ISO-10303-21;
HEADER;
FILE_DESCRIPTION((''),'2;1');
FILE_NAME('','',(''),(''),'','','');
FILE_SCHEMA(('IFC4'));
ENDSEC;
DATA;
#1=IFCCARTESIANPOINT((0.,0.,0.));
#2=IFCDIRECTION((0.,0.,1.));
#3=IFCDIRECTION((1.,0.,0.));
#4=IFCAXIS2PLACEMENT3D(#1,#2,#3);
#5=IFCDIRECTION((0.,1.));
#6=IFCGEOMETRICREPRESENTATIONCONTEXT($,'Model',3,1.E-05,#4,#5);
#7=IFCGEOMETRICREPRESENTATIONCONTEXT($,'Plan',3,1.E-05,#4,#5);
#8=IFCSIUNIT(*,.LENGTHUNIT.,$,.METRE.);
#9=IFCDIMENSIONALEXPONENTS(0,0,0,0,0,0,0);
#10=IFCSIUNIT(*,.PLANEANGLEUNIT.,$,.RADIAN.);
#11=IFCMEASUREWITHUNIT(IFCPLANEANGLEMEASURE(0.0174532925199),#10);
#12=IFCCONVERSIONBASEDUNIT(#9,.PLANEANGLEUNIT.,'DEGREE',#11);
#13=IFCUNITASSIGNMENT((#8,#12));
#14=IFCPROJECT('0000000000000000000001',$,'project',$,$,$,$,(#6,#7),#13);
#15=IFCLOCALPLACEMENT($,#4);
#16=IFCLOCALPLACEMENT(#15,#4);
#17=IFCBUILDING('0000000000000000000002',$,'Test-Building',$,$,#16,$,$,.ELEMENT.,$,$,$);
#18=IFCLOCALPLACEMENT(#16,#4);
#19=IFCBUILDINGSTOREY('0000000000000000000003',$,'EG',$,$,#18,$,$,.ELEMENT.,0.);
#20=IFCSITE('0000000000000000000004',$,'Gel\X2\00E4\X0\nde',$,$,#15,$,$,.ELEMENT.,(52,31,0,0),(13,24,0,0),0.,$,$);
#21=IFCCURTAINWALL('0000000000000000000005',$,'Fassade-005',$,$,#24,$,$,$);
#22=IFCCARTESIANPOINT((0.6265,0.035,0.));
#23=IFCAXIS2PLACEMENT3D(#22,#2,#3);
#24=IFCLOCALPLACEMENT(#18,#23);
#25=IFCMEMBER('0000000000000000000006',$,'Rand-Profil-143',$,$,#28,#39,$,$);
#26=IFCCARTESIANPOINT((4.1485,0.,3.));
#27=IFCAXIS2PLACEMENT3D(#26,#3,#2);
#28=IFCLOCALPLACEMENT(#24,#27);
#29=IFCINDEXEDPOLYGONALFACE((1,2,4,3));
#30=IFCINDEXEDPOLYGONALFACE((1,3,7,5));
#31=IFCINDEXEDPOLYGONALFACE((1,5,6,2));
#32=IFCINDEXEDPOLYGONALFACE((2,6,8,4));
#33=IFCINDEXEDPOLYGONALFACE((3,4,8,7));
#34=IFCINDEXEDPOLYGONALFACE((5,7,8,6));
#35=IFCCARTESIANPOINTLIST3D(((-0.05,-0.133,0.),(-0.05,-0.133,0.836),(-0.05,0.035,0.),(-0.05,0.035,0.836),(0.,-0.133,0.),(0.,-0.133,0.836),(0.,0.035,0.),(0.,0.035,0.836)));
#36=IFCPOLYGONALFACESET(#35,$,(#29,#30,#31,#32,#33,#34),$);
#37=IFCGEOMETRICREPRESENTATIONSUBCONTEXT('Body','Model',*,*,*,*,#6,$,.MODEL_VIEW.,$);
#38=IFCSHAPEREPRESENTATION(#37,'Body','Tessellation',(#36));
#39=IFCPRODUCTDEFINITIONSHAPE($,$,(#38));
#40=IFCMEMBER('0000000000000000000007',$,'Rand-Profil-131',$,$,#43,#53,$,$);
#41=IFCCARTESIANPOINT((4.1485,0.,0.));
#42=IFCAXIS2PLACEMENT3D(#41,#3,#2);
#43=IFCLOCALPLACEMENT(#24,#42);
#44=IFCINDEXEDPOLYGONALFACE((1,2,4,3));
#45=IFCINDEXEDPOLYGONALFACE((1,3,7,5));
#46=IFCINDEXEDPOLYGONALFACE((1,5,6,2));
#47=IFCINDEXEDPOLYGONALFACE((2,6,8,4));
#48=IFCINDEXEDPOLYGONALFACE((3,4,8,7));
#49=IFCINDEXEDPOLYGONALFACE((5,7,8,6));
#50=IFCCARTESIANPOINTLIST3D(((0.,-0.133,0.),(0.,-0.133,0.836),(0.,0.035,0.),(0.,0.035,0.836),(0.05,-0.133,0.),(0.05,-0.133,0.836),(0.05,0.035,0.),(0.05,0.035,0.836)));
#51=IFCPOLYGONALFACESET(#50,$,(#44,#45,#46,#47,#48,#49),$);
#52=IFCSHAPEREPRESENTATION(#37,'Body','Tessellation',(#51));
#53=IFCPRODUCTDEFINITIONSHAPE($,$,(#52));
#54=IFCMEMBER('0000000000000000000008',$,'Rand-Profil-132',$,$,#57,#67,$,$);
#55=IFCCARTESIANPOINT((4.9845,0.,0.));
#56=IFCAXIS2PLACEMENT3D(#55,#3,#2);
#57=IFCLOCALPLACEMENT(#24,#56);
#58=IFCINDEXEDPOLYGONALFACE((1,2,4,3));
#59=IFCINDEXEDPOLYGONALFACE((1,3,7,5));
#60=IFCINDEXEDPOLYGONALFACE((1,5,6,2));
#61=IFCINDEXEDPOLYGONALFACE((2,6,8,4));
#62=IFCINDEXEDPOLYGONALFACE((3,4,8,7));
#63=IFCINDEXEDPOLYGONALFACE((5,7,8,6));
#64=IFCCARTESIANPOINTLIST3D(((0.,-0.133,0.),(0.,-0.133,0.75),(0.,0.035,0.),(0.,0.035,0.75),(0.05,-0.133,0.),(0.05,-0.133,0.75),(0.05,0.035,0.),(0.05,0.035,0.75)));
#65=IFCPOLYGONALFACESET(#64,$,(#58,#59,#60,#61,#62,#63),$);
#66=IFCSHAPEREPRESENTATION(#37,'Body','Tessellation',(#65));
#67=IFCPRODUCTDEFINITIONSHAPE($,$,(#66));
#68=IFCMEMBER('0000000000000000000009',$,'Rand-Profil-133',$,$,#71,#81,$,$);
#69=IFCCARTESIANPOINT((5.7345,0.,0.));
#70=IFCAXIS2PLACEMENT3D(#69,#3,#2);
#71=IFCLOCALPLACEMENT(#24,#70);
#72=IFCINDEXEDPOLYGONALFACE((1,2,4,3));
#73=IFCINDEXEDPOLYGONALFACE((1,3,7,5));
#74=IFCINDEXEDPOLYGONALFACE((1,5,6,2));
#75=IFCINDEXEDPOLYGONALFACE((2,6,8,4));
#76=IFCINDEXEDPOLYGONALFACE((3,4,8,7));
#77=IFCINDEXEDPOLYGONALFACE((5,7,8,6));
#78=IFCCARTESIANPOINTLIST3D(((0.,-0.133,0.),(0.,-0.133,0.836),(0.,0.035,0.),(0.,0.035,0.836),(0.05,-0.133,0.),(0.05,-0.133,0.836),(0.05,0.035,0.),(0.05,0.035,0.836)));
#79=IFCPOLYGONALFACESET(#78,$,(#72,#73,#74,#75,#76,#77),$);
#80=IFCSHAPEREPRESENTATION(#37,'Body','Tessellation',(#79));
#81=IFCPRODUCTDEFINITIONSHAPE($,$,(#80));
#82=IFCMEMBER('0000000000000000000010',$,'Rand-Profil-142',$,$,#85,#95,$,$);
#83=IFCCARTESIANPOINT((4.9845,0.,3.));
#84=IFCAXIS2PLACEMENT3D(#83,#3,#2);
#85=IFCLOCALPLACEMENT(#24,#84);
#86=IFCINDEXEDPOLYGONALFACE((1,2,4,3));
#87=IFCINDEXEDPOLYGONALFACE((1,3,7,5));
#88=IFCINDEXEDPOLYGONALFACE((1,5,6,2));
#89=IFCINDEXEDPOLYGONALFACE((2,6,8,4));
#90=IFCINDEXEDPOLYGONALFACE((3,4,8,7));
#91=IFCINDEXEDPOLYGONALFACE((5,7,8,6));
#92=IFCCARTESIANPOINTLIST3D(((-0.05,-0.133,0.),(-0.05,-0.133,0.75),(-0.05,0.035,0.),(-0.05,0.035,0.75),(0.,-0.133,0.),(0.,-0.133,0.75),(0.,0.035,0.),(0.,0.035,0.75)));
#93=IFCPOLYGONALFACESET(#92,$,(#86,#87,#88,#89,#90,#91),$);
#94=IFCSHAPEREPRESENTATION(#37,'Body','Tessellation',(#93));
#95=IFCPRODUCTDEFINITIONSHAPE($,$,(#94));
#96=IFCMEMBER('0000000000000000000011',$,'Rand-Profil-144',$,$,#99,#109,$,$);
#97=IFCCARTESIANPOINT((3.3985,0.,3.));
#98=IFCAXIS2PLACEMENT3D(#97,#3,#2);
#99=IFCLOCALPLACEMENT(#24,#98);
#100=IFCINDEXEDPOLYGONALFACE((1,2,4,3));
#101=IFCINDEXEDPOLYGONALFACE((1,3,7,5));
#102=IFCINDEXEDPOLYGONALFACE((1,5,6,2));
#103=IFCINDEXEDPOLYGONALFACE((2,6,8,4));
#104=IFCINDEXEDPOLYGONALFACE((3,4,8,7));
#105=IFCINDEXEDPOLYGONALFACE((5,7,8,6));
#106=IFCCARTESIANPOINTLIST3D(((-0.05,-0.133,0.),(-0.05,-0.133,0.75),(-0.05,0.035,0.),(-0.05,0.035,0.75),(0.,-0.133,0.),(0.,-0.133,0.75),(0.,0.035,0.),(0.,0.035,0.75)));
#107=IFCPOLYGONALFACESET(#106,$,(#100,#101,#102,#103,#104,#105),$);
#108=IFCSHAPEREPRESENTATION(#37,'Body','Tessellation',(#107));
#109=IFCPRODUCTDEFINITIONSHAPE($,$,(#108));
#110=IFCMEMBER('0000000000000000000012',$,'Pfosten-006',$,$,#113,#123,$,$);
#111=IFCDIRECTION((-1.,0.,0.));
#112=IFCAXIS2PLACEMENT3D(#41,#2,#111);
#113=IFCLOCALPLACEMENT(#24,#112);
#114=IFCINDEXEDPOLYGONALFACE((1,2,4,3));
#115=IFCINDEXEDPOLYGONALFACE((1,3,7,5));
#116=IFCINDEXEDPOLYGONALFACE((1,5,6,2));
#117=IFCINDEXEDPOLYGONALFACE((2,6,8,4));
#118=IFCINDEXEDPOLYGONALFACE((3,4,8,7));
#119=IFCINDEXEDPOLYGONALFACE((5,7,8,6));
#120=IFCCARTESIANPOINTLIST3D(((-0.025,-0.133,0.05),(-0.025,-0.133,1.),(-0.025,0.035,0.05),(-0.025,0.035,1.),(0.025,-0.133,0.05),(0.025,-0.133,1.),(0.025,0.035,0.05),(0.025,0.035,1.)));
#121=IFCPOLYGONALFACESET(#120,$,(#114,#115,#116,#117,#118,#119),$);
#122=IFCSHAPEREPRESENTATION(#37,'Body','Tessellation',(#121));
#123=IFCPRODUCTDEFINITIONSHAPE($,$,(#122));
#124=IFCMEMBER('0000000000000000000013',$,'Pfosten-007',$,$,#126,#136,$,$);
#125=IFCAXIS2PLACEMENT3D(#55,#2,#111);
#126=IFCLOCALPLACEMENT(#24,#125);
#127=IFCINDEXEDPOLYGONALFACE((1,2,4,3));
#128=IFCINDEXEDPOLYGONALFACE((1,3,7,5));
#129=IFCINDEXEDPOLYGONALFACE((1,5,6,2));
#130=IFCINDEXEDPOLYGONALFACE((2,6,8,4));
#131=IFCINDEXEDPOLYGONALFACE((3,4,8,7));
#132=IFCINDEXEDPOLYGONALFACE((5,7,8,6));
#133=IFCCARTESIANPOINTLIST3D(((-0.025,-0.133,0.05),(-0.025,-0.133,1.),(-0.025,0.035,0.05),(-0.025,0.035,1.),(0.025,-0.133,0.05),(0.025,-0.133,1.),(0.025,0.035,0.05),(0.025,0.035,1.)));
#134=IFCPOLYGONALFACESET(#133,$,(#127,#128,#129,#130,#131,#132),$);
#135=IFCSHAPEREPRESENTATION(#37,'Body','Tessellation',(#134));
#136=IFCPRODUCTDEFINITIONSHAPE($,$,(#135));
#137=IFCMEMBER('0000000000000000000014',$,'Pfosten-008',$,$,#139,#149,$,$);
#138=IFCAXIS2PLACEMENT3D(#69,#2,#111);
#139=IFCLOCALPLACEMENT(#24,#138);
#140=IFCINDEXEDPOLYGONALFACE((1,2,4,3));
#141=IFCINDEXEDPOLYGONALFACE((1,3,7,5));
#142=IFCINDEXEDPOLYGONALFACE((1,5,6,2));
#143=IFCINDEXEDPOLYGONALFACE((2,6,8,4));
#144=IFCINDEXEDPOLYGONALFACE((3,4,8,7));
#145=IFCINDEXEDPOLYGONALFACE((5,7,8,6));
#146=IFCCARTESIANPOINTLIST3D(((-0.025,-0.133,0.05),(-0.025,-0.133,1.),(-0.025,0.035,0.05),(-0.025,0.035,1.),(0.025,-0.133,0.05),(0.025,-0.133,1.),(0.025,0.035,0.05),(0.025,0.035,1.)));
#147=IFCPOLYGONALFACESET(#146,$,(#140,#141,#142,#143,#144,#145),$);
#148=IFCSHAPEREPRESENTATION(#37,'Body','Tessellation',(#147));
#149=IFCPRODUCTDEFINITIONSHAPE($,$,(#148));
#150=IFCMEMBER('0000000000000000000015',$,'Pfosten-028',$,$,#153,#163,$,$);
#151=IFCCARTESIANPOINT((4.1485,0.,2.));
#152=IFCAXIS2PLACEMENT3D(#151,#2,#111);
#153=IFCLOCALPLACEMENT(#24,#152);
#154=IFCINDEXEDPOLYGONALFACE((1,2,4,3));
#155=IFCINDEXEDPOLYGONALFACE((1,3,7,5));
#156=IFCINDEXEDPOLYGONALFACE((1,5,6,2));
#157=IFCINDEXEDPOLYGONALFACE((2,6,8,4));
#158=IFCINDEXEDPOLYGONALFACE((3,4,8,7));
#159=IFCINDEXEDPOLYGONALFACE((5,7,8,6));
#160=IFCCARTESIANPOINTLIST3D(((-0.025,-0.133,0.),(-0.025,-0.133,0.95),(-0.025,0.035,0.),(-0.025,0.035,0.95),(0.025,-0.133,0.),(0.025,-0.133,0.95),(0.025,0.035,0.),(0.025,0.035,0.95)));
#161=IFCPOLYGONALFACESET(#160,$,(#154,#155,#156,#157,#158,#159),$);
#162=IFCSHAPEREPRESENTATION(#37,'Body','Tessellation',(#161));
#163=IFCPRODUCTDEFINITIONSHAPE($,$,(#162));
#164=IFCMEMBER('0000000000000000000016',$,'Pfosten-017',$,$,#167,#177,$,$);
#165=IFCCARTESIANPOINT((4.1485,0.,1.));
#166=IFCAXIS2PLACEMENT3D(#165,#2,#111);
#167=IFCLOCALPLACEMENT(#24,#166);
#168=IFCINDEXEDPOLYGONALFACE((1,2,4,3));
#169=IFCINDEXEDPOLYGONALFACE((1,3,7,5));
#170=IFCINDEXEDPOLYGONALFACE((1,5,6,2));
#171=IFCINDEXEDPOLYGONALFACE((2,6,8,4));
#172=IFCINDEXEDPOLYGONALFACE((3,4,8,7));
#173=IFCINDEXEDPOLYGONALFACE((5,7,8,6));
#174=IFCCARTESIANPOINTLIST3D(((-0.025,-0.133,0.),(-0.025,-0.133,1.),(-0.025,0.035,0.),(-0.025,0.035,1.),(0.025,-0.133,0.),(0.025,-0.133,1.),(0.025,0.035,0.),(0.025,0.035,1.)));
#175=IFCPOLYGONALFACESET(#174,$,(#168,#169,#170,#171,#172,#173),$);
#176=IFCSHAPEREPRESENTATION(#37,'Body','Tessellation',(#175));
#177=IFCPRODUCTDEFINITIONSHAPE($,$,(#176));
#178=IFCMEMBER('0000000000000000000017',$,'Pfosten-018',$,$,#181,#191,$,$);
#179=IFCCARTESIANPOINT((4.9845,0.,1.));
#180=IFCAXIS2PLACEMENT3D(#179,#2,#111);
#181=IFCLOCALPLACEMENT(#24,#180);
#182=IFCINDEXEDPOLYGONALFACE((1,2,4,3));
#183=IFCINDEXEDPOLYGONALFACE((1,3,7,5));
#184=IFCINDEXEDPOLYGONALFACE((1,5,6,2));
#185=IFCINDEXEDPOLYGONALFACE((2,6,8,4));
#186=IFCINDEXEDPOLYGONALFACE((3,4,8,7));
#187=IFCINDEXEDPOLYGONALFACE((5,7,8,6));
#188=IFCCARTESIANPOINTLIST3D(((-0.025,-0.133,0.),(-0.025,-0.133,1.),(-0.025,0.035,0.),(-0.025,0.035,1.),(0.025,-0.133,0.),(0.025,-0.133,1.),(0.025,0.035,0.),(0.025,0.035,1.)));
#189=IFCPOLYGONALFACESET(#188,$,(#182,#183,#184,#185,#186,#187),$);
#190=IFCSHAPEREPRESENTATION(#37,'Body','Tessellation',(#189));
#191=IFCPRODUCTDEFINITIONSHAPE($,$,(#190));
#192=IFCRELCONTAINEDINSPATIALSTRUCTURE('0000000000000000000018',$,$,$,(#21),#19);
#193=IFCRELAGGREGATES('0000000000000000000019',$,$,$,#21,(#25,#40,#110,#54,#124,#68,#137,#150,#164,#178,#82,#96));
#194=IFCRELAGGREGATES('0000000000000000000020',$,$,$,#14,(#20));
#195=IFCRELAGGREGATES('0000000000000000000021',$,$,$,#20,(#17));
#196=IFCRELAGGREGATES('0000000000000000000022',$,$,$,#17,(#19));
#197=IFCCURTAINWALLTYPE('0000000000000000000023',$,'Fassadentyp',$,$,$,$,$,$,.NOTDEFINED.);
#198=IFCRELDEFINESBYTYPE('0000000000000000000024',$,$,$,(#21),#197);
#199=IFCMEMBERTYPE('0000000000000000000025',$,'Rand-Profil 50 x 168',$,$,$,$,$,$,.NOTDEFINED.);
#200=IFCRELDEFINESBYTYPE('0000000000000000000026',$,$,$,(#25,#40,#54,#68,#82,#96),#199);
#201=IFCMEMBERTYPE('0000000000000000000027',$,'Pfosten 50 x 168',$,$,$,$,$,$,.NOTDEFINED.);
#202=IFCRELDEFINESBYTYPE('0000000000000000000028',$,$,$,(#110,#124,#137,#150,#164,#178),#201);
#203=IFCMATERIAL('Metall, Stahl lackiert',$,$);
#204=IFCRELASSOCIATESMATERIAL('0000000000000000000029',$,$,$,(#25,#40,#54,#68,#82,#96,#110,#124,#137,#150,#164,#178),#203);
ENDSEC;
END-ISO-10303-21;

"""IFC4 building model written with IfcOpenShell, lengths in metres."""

from ifc_helpers import new_model, entity, si_unit, converted_unit, direction, frame, origin_with_axes, place, context, subcontext, project, spatial, polyline, outline, extrude, material, type_object, element, aggregate, save


model = new_model("IFC4")

# Units and contexts
model_context = context("Model", 3, precision=1e-05, world=origin_with_axes(), true_north=direction((0.0, 1.0)))
plan_context = context("Plan", 3, precision=1e-05, world=origin_with_axes(), true_north=direction((0.0, 1.0)))
body_context = subcontext(model_context, "Body", "Model", "MODEL_VIEW")
ifc_project = project(units=[si_unit("LENGTHUNIT", "METRE"), converted_unit("PLANEANGLEUNIT", "DEGREE", entity("IfcPlaneAngleMeasure", 0.0174532925199), si_unit("PLANEANGLEUNIT", "RADIAN"), dimensions=[0, 0, 0, 0, 0, 0, 0])], contexts=[model_context, plan_context])

# Site, building, storey
site_placement = place(None, origin_with_axes())
site = spatial("IfcSite", under=ifc_project, at=site_placement, Name="Gelände", CompositionType="ELEMENT", RefLatitude=(52, 31, 0, 0), RefLongitude=(13, 24, 0, 0), RefElevation=0.0)
building_placement = place(site_placement, origin_with_axes())
building = spatial("IfcBuilding", under=site, at=building_placement, Name="Test-Building", CompositionType="ELEMENT")
storey_placement = place(building_placement, origin_with_axes())
storey = spatial("IfcBuildingStorey", under=building, at=storey_placement, Name="EG", CompositionType="ELEMENT", Elevation=0.0)

# Curtain wall, members
curtain_wall_type = type_object("IfcCurtainWallType", Name="Fassadentyp", PredefinedType="NOTDEFINED")
curtain_wall_placement = place(storey_placement, frame((0.6265, 0.035, 0.0), z_axis=(0.0, 0.0, 1.0), x_axis=(1.0, 0.0, 0.0)))
curtain_wall = element("IfcCurtainWall", 1, at=curtain_wall_placement, inside=storey, type_object=curtain_wall_type, Name="Fassade-005")
ifc_material_1 = material(Name="Metall, Stahl lackiert")
member_type_1 = type_object("IfcMemberType", Name="Rand-Profil 50 x 168", PredefinedType="NOTDEFINED")
member_1_placement = place(curtain_wall_placement, frame((4.1485, 0.0, 3.0), z_axis=(1.0, 0.0, 0.0), x_axis=(0.0, 0.0, 1.0)))
member_1 = element("IfcMember", 2, at=member_1_placement, type_object=member_type_1, material=ifc_material_1, Name="Rand-Profil-143", context=body_context, shape_type="SweptSolid", body=[
    extrude(outline(polyline([(-0.133, 0.05), (-0.133, 0.0), (0.035, 0.0), (0.035, 0.05), (-0.133, 0.05)])), frame((0.0, 0.0, 0.0), z_axis=(0.0, 0.0, 1.0), x_axis=(0.0, 1.0, 0.0)), (0.0, 0.0, 1.0), 0.836),
])
member_2_placement = place(curtain_wall_placement, frame((4.1485, 0.0, 0.0), z_axis=(1.0, 0.0, 0.0), x_axis=(0.0, 0.0, 1.0)))
member_2 = element("IfcMember", 3, at=member_2_placement, type_object=member_type_1, material=ifc_material_1, Name="Rand-Profil-131", context=body_context, shape_type="SweptSolid", body=[
    extrude(outline(polyline([(-0.133, -0.05), (0.035, -0.05), (0.035, 0.0), (-0.133, 0.0), (-0.133, -0.05)])), frame((0.0, 0.0, 0.0), z_axis=(0.0, 0.0, 1.0), x_axis=(0.0, 1.0, 0.0)), (0.0, 0.0, 1.0), 0.836),
])
member_3_placement = place(curtain_wall_placement, frame((4.9845, 0.0, 0.0), z_axis=(1.0, 0.0, 0.0), x_axis=(0.0, 0.0, 1.0)))
member_3 = element("IfcMember", 4, at=member_3_placement, type_object=member_type_1, material=ifc_material_1, Name="Rand-Profil-132", context=body_context, shape_type="SweptSolid", body=[
    extrude(outline(polyline([(-0.133, -0.05), (0.035, -0.05), (0.035, 0.0), (-0.133, 0.0), (-0.133, -0.05)])), frame((0.0, 0.0, 0.0), z_axis=(0.0, 0.0, 1.0), x_axis=(0.0, 1.0, 0.0)), (0.0, 0.0, 1.0), 0.75),
])
member_4_placement = place(curtain_wall_placement, frame((5.7345, 0.0, 0.0), z_axis=(1.0, 0.0, 0.0), x_axis=(0.0, 0.0, 1.0)))
member_4 = element("IfcMember", 5, at=member_4_placement, type_object=member_type_1, material=ifc_material_1, Name="Rand-Profil-133", context=body_context, shape_type="SweptSolid", body=[
    extrude(outline(polyline([(-0.133, -0.05), (0.035, -0.05), (0.035, 0.0), (-0.133, 0.0), (-0.133, -0.05)])), frame((0.0, 0.0, 0.0), z_axis=(0.0, 0.0, 1.0), x_axis=(0.0, 1.0, 0.0)), (0.0, 0.0, 1.0), 0.836),
])
member_5_placement = place(curtain_wall_placement, frame((4.9845, 0.0, 3.0), z_axis=(1.0, 0.0, 0.0), x_axis=(0.0, 0.0, 1.0)))
member_5 = element("IfcMember", 6, at=member_5_placement, type_object=member_type_1, material=ifc_material_1, Name="Rand-Profil-142", context=body_context, shape_type="SweptSolid", body=[
    extrude(outline(polyline([(-0.133, 0.05), (-0.133, 0.0), (0.035, 0.0), (0.035, 0.05), (-0.133, 0.05)])), frame((0.0, 0.0, 0.0), z_axis=(0.0, 0.0, 1.0), x_axis=(0.0, 1.0, 0.0)), (0.0, 0.0, 1.0), 0.75),
])
member_6_placement = place(curtain_wall_placement, frame((3.3985, 0.0, 3.0), z_axis=(1.0, 0.0, 0.0), x_axis=(0.0, 0.0, 1.0)))
member_6 = element("IfcMember", 7, at=member_6_placement, type_object=member_type_1, material=ifc_material_1, Name="Rand-Profil-144", context=body_context, shape_type="SweptSolid", body=[
    extrude(outline(polyline([(-0.133, 0.05), (-0.133, 0.0), (0.035, 0.0), (0.035, 0.05), (-0.133, 0.05)])), frame((0.0, 0.0, 0.0), z_axis=(0.0, 0.0, 1.0), x_axis=(0.0, 1.0, 0.0)), (0.0, 0.0, 1.0), 0.75),
])
member_type_2 = type_object("IfcMemberType", Name="Pfosten 50 x 168", PredefinedType="NOTDEFINED")
member_7_placement = place(curtain_wall_placement, frame((4.1485, 0.0, 0.0), z_axis=(0.0, 0.0, 1.0), x_axis=(-1.0, 0.0, 0.0)))
member_7 = element("IfcMember", 8, at=member_7_placement, type_object=member_type_2, material=ifc_material_1, Name="Pfosten-006", context=body_context, shape_type="SweptSolid", body=[
    extrude(outline(polyline([(-0.025, 0.133), (-0.025, -0.035), (0.025, -0.035), (0.025, 0.133), (-0.025, 0.133)])), frame((0.0, 0.0, 0.05), z_axis=(0.0, 0.0, 1.0), x_axis=(-1.0, 0.0, 0.0)), (0.0, 0.0, 1.0), 0.95),
])
member_8_placement = place(curtain_wall_placement, frame((4.9845, 0.0, 0.0), z_axis=(0.0, 0.0, 1.0), x_axis=(-1.0, 0.0, 0.0)))
member_8 = element("IfcMember", 9, at=member_8_placement, type_object=member_type_2, material=ifc_material_1, Name="Pfosten-007", context=body_context, shape_type="SweptSolid", body=[
    extrude(outline(polyline([(-0.025, 0.133), (-0.025, -0.035), (0.025, -0.035), (0.025, 0.133), (-0.025, 0.133)])), frame((0.0, 0.0, 0.05), z_axis=(0.0, 0.0, 1.0), x_axis=(-1.0, 0.0, 0.0)), (0.0, 0.0, 1.0), 0.95),
])
member_9_placement = place(curtain_wall_placement, frame((5.7345, 0.0, 0.0), z_axis=(0.0, 0.0, 1.0), x_axis=(-1.0, 0.0, 0.0)))
member_9 = element("IfcMember", 10, at=member_9_placement, type_object=member_type_2, material=ifc_material_1, Name="Pfosten-008", context=body_context, shape_type="SweptSolid", body=[
    extrude(outline(polyline([(-0.025, 0.133), (-0.025, -0.035), (0.025, -0.035), (0.025, 0.133), (-0.025, 0.133)])), frame((0.0, 0.0, 0.05), z_axis=(0.0, 0.0, 1.0), x_axis=(-1.0, 0.0, 0.0)), (0.0, 0.0, 1.0), 0.95),
])
member_10_placement = place(curtain_wall_placement, frame((4.1485, 0.0, 2.0), z_axis=(0.0, 0.0, 1.0), x_axis=(-1.0, 0.0, 0.0)))
member_10 = element("IfcMember", 11, at=member_10_placement, type_object=member_type_2, material=ifc_material_1, Name="Pfosten-028", context=body_context, shape_type="SweptSolid", body=[
    extrude(outline(polyline([(-0.025, 0.133), (-0.025, -0.035), (0.025, -0.035), (0.025, 0.133), (-0.025, 0.133)])), frame((0.0, 0.0, 0.0), z_axis=(0.0, 0.0, 1.0), x_axis=(-1.0, 0.0, 0.0)), (0.0, 0.0, 1.0), 0.95),
])
member_11_placement = place(curtain_wall_placement, frame((4.1485, 0.0, 1.0), z_axis=(0.0, 0.0, 1.0), x_axis=(-1.0, 0.0, 0.0)))
member_11 = element("IfcMember", 12, at=member_11_placement, type_object=member_type_2, material=ifc_material_1, Name="Pfosten-017", context=body_context, shape_type="SweptSolid", body=[
    extrude(outline(polyline([(-0.025, 0.133), (-0.025, -0.035), (0.025, -0.035), (0.025, 0.133), (-0.025, 0.133)])), frame((0.0, 0.0, 0.0), z_axis=(0.0, 0.0, 1.0), x_axis=(-1.0, 0.0, 0.0)), (0.0, 0.0, 1.0), 1.0),
])
member_12_placement = place(curtain_wall_placement, frame((4.9845, 0.0, 1.0), z_axis=(0.0, 0.0, 1.0), x_axis=(-1.0, 0.0, 0.0)))
member_12 = element("IfcMember", 13, at=member_12_placement, type_object=member_type_2, material=ifc_material_1, Name="Pfosten-018", context=body_context, shape_type="SweptSolid", body=[
    extrude(outline(polyline([(-0.025, 0.133), (-0.025, -0.035), (0.025, -0.035), (0.025, 0.133), (-0.025, 0.133)])), frame((0.0, 0.0, 0.0), z_axis=(0.0, 0.0, 1.0), x_axis=(-1.0, 0.0, 0.0)), (0.0, 0.0, 1.0), 1.0),
])
aggregate(curtain_wall, [member_1, member_2, member_7, member_3, member_8, member_4, member_9, member_10, member_11, member_12, member_5, member_6])

save(model, "model.ifc")
